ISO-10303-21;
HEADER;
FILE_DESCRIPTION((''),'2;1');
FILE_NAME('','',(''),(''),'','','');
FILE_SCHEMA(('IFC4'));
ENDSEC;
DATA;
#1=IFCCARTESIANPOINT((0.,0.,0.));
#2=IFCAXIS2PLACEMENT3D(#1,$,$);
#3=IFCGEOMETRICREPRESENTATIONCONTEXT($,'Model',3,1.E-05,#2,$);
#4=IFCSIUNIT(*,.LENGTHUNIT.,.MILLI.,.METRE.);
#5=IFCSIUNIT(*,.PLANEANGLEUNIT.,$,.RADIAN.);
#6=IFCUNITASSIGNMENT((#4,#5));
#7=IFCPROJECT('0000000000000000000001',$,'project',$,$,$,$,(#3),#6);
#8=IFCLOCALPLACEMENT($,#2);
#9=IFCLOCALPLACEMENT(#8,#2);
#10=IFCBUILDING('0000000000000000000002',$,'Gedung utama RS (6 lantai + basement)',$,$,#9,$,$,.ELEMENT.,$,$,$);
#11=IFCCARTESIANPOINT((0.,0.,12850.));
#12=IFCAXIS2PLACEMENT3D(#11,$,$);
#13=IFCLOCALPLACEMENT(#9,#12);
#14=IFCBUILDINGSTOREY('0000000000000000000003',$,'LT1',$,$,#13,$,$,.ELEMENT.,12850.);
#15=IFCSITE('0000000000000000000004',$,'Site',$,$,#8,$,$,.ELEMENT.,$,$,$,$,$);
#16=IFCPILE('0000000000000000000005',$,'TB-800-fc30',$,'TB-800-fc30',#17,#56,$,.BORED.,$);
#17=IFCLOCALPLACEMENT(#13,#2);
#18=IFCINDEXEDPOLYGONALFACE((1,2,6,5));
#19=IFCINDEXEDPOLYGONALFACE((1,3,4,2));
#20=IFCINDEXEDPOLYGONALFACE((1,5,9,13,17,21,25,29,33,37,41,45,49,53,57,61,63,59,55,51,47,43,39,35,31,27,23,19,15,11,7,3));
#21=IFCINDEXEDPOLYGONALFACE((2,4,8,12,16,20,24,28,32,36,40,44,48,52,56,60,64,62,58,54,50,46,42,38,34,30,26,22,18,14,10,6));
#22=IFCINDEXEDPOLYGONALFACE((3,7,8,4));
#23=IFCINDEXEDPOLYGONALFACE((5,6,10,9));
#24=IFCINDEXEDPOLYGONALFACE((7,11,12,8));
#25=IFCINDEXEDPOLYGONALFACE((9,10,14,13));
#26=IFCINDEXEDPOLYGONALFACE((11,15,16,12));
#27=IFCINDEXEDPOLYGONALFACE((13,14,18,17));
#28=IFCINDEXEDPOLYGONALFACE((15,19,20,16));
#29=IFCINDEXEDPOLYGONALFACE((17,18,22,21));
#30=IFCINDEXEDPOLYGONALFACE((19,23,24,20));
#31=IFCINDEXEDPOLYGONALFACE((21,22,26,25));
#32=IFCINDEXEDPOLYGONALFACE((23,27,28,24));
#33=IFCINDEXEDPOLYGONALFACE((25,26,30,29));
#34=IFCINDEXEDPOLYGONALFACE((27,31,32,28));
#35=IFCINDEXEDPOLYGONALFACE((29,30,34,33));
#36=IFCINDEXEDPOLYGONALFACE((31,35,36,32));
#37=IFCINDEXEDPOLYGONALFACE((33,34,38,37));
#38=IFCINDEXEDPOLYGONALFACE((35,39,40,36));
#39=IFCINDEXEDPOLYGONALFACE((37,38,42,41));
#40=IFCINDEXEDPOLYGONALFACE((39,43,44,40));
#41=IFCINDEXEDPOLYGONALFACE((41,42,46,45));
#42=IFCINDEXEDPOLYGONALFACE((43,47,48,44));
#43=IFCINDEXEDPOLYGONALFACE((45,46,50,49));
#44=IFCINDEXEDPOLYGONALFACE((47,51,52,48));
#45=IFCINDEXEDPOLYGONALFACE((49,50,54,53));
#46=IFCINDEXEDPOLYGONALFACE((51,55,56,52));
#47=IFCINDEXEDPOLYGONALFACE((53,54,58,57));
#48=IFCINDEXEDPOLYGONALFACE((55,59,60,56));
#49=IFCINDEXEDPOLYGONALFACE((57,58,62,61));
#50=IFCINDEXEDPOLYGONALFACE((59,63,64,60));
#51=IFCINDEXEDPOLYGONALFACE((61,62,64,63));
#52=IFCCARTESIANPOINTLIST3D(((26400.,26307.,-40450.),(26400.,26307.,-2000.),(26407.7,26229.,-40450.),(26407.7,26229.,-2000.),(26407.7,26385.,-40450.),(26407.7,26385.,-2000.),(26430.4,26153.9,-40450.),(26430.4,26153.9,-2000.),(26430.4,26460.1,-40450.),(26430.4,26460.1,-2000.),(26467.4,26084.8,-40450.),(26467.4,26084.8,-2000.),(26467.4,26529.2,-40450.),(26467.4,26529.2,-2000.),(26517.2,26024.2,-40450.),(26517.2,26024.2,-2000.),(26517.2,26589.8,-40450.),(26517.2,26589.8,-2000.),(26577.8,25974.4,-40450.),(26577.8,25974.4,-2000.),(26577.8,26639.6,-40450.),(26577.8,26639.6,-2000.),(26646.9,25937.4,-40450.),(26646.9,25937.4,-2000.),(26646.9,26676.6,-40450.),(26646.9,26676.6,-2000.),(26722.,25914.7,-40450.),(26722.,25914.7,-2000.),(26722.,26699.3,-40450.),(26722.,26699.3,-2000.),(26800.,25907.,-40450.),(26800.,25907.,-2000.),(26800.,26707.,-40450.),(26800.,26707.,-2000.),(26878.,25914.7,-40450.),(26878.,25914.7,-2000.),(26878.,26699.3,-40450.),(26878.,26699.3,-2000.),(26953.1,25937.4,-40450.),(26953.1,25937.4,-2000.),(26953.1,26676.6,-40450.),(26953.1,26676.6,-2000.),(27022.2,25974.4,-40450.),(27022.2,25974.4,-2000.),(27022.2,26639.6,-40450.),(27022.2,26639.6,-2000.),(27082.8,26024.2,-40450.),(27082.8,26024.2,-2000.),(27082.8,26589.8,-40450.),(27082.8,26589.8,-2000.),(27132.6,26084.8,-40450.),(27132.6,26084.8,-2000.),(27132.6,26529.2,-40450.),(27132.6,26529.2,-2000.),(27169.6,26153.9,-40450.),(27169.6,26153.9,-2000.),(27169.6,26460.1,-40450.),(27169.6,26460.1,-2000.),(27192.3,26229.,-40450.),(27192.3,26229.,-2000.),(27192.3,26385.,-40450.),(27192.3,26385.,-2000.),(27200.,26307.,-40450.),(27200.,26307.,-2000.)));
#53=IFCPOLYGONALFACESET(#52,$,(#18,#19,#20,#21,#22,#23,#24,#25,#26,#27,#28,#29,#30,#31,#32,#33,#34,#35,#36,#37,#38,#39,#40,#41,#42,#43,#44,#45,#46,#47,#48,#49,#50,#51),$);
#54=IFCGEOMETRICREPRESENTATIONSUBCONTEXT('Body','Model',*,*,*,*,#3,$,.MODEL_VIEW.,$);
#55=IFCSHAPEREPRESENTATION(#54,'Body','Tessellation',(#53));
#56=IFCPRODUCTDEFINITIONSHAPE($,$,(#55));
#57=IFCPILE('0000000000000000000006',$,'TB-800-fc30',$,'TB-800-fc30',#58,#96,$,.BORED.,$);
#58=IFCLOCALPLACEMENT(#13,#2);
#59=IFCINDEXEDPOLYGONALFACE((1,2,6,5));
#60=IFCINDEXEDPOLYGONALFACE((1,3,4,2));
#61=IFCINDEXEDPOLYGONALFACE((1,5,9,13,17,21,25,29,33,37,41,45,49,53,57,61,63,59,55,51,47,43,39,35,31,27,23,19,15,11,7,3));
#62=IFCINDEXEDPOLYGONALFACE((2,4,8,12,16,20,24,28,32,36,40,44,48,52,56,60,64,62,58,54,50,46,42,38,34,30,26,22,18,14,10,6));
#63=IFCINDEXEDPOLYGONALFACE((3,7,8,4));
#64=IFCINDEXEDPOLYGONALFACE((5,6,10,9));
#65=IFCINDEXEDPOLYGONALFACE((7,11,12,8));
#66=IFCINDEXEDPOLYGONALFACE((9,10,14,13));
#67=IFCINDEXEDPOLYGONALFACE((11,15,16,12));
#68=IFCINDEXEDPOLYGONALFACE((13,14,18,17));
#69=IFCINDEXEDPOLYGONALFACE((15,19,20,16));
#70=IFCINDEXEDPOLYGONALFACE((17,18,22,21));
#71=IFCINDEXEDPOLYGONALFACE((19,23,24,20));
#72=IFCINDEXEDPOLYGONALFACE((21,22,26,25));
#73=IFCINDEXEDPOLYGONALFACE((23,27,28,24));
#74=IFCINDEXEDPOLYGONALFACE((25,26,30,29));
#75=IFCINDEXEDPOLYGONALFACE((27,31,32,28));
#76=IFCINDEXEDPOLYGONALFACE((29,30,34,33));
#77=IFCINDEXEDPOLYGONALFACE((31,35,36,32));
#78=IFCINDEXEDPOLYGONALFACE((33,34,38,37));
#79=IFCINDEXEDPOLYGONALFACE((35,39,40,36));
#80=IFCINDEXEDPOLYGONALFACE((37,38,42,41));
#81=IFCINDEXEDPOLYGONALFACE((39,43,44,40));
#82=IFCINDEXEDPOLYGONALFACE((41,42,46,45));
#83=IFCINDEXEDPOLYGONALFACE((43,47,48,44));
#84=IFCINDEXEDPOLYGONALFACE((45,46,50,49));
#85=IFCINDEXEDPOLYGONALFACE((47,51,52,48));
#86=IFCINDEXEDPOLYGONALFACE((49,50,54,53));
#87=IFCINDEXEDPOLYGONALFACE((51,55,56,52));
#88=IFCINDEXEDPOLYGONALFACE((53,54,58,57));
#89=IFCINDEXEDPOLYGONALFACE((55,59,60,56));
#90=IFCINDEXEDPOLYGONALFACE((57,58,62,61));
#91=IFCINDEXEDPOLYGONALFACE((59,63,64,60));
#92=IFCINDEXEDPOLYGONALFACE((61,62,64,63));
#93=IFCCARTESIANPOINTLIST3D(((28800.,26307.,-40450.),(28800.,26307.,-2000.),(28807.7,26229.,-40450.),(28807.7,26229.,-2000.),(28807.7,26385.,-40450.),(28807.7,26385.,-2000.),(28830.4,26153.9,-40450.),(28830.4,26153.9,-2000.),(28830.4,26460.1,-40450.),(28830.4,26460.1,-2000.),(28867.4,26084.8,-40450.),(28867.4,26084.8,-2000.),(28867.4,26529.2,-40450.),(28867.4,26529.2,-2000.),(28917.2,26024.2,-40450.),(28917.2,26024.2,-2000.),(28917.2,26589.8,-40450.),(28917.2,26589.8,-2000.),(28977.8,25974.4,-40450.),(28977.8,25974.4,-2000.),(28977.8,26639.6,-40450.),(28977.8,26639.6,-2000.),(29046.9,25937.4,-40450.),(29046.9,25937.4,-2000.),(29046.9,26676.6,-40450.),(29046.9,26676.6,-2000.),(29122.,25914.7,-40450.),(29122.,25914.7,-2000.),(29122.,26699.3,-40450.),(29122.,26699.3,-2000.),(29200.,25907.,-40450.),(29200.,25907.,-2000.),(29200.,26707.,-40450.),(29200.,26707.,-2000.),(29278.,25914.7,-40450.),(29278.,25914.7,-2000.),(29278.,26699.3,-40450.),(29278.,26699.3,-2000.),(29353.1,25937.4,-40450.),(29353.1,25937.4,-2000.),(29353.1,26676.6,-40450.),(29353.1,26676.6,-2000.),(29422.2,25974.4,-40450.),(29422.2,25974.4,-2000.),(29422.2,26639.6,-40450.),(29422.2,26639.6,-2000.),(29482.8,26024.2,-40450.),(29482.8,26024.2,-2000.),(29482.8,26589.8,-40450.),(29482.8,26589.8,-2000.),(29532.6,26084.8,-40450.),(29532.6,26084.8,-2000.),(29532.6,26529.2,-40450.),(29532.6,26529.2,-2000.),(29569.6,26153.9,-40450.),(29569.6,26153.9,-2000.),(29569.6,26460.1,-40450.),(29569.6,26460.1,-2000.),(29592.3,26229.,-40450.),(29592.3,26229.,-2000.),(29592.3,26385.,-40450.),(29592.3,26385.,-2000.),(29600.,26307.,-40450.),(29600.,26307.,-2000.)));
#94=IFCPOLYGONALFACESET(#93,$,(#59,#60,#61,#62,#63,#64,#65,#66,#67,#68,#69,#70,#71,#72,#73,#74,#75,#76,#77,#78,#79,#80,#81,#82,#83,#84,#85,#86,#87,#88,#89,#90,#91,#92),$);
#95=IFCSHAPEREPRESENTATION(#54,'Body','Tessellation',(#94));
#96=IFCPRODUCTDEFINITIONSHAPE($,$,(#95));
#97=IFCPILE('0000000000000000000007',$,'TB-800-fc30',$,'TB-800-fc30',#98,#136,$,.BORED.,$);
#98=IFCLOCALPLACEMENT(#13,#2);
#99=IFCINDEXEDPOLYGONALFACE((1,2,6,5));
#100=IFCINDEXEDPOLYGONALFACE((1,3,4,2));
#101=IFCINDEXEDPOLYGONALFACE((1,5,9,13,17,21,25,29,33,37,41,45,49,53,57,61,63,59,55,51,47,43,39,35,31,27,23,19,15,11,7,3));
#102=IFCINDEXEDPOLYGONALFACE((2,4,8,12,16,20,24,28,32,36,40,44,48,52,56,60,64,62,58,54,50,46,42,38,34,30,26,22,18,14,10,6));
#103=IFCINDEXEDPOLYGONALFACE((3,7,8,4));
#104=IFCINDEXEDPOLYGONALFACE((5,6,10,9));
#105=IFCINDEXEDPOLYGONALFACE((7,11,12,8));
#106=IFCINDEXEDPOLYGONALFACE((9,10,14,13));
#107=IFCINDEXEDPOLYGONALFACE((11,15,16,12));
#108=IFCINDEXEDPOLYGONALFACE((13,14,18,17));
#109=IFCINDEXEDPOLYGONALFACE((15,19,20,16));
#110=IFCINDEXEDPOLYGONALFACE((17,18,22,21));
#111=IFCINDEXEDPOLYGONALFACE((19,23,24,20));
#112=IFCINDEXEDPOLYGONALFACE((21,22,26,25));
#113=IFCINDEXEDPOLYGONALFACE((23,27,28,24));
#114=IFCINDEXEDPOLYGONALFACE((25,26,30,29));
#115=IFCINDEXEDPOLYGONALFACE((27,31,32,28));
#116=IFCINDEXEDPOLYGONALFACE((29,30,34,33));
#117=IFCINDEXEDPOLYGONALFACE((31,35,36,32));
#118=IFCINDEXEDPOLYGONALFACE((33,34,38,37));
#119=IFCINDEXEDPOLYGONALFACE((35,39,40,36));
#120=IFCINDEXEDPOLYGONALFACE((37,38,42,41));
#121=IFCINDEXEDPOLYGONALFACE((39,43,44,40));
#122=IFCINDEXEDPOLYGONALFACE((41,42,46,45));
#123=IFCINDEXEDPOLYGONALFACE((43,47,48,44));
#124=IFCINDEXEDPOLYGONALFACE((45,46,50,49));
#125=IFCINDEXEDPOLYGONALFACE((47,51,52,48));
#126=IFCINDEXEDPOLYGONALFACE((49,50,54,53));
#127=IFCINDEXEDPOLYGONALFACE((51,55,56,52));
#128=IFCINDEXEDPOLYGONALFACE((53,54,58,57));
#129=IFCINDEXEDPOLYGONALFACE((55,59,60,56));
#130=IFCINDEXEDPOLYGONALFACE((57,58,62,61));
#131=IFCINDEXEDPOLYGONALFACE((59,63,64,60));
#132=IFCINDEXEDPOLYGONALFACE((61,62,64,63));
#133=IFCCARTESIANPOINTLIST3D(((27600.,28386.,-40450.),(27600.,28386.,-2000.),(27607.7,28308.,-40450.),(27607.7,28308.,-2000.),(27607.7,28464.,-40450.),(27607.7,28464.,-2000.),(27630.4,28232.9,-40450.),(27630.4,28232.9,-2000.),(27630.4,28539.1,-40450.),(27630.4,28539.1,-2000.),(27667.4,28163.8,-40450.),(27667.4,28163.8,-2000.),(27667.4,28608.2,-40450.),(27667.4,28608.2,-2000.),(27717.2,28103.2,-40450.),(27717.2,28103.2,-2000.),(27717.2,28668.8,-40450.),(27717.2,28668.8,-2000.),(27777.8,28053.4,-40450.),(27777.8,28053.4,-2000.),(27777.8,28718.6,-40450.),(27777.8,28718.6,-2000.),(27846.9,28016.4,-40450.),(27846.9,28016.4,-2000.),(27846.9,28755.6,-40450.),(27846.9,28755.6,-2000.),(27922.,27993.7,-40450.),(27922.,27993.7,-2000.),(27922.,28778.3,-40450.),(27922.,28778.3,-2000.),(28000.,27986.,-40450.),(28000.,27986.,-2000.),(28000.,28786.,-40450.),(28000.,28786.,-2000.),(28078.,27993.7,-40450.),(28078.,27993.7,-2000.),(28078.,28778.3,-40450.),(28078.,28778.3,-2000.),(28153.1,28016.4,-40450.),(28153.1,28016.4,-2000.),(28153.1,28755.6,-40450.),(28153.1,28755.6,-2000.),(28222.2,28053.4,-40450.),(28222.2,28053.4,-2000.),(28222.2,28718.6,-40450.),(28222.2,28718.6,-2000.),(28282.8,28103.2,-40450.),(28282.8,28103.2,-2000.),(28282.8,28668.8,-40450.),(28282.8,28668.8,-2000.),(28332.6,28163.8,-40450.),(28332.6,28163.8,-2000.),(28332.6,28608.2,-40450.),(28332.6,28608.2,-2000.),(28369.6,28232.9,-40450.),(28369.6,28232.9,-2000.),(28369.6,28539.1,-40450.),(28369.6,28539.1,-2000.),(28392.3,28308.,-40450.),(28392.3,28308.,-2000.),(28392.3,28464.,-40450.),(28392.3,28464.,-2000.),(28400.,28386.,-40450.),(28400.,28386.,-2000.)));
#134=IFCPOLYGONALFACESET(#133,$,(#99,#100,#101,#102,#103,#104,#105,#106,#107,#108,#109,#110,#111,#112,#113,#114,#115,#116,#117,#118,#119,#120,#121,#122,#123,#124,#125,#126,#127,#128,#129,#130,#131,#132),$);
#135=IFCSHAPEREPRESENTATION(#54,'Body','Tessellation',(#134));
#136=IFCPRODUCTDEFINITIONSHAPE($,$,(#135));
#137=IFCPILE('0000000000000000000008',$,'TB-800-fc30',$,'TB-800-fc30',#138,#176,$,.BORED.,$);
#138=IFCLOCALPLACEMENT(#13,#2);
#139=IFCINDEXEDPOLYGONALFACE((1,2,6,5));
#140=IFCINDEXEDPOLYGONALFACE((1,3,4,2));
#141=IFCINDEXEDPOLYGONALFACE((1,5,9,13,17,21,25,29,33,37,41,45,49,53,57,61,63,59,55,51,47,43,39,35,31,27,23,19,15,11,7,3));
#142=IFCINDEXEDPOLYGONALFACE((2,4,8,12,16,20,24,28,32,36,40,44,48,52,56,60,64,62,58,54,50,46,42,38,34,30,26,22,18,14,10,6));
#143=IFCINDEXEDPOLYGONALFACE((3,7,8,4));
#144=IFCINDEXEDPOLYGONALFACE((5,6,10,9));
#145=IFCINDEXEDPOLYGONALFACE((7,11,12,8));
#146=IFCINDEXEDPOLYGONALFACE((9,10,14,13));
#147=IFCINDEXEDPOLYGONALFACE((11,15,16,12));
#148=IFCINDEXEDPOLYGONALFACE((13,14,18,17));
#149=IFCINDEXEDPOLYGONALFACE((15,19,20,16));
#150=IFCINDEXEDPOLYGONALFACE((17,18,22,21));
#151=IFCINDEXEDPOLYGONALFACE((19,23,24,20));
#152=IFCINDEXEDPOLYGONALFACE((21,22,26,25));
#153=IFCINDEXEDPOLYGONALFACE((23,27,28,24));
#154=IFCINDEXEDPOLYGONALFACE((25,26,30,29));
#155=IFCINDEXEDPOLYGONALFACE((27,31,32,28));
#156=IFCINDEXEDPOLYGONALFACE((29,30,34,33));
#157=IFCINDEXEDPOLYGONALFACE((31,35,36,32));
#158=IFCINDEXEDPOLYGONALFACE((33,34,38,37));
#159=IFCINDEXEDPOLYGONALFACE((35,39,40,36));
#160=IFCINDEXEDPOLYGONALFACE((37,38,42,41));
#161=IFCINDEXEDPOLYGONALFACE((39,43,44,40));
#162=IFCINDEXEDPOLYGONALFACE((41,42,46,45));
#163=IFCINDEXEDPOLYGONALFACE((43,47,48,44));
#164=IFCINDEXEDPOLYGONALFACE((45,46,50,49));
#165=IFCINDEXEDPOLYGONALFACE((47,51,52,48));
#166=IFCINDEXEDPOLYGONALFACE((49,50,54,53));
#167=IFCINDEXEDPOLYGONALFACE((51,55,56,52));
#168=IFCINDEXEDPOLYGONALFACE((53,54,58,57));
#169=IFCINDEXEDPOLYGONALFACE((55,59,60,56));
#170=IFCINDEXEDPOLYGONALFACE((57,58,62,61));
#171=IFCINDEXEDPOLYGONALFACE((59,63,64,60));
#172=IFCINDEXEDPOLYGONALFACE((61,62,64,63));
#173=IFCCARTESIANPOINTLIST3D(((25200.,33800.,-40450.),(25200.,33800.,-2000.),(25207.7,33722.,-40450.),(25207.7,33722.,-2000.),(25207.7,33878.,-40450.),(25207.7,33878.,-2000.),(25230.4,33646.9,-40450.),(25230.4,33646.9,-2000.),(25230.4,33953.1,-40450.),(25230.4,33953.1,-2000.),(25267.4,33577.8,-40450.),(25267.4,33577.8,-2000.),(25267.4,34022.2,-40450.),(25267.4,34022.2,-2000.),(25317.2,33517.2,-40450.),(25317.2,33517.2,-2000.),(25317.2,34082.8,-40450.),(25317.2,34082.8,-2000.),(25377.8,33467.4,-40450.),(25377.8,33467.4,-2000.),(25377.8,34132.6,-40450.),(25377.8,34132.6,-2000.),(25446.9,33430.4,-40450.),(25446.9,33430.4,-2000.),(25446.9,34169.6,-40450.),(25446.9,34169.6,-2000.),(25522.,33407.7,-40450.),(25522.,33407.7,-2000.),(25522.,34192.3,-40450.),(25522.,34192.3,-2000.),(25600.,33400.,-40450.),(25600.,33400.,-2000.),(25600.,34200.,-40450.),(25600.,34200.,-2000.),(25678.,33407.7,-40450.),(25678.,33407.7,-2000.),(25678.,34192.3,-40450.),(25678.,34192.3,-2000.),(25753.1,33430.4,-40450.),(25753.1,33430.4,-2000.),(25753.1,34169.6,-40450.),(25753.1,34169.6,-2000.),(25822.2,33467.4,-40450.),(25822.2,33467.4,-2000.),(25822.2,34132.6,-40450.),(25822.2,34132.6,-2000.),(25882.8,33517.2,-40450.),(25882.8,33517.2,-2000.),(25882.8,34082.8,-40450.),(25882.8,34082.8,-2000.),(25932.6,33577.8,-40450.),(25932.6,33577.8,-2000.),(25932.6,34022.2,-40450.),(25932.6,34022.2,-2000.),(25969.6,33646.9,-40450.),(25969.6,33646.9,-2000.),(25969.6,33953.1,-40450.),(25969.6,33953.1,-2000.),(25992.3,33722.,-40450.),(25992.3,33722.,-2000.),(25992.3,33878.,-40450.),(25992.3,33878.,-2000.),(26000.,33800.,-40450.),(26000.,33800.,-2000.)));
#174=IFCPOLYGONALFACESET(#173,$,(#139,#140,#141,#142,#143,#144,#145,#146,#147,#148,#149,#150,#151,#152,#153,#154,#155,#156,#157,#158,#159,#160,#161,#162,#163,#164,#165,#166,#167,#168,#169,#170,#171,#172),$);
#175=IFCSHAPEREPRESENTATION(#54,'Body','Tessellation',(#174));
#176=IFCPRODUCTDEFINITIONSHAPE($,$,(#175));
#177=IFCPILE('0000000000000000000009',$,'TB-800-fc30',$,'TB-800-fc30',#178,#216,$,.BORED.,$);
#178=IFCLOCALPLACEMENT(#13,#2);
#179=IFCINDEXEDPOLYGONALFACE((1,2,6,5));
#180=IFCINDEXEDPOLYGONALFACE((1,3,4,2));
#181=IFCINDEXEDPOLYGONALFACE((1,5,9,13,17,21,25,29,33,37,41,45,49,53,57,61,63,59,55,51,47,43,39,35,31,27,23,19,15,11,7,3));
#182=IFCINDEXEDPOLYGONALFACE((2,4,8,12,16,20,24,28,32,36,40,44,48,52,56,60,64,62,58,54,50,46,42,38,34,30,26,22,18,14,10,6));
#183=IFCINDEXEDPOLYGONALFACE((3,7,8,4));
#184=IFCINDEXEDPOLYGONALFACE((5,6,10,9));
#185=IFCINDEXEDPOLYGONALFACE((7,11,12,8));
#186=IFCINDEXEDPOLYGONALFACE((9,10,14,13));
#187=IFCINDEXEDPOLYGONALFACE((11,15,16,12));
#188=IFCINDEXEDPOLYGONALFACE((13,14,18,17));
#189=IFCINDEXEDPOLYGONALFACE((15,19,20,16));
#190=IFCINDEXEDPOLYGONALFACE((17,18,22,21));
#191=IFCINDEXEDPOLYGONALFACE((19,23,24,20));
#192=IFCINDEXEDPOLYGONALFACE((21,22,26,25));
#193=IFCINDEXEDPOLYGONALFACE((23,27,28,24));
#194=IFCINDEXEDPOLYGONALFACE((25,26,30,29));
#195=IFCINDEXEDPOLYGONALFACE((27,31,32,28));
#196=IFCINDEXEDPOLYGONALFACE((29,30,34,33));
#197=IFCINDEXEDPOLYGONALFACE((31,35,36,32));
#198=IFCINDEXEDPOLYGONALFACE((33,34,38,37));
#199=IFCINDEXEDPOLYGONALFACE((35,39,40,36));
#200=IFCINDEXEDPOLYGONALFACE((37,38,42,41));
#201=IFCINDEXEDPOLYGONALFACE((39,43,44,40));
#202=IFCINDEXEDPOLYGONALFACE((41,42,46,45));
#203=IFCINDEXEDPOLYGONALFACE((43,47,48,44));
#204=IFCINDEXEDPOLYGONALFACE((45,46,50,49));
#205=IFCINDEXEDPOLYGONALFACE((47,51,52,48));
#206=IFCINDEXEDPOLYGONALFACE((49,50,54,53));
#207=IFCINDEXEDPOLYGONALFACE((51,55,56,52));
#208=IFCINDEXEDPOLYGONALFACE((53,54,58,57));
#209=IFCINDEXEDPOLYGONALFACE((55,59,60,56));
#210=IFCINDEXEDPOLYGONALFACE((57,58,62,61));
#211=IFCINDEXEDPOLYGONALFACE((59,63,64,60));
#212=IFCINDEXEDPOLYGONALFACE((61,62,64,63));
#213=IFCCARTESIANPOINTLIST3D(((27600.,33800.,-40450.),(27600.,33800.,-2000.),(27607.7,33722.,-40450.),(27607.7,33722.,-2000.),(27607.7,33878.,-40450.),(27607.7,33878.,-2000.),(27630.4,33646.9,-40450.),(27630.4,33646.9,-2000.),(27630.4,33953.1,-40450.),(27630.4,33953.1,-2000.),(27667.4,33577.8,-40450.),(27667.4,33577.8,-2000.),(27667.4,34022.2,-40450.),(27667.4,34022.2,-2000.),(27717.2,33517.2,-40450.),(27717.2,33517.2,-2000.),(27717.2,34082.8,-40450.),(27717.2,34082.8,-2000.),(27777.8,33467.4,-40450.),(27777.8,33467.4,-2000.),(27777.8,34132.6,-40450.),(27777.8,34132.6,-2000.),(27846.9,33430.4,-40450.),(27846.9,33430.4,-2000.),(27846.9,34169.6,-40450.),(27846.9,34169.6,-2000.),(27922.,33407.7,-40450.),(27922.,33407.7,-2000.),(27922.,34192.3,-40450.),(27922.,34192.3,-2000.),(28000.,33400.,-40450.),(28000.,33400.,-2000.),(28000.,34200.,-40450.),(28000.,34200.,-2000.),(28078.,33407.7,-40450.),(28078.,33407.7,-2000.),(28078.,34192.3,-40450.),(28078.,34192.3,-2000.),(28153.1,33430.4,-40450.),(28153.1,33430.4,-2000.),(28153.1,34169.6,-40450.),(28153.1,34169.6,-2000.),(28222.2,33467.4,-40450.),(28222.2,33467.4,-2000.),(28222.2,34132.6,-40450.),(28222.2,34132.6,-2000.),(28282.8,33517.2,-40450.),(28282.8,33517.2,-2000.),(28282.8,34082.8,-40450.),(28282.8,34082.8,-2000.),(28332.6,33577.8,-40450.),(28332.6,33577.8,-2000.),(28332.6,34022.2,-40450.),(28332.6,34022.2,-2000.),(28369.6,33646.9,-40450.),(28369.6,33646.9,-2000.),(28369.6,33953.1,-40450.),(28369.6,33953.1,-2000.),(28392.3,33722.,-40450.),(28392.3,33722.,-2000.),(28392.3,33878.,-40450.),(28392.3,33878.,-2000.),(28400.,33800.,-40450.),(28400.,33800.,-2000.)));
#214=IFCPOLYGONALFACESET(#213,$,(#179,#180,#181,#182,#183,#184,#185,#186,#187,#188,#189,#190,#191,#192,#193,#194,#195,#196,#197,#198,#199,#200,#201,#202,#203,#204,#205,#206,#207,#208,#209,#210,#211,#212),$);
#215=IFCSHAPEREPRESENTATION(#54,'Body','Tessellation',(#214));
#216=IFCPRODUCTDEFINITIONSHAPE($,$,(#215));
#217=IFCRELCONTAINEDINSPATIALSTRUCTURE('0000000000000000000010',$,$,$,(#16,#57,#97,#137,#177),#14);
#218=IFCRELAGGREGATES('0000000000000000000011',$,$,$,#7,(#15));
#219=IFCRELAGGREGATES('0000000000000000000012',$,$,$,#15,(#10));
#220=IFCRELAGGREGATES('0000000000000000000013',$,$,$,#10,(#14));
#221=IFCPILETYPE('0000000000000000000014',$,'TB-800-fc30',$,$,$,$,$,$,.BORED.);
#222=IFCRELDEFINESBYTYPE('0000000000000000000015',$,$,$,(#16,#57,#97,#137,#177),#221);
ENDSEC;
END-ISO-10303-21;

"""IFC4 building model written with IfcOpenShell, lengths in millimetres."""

from ifc_helpers import new_model, si_unit, frame, origin, origin_2d, place, context, subcontext, project, spatial, circle, extrude, material_profile, profile_set, profile_usage, type_object, element, save


model = new_model("IFC4")

# Units and contexts
model_context = context("Model", 3, precision=1e-05, world=origin())
body_context = subcontext(model_context, "Body", "Model", "MODEL_VIEW")
ifc_project = project(units=[si_unit("LENGTHUNIT", "METRE", prefix="MILLI"), si_unit("PLANEANGLEUNIT", "RADIAN")], contexts=[model_context])

# Site, building, storey
site_placement = place(None, origin())
site = spatial("IfcSite", under=ifc_project, at=site_placement, Name="Site", CompositionType="ELEMENT")
building_placement = place(site_placement, origin())
building = spatial("IfcBuilding", under=site, at=building_placement, Name="Gedung utama RS (6 lantai + basement)", CompositionType="ELEMENT")
storey_placement = place(building_placement, frame((0.0, 0.0, 12850.0)))
storey = spatial("IfcBuildingStorey", under=building, at=storey_placement, Name="LT1", CompositionType="ELEMENT", Elevation=12850.0)

# Piles
ifc_material_profile_1 = material_profile(None, circle(Radius=400.0, at=origin_2d()), Name="TB-800-fc30")
ifc_profile_set_1 = profile_set([ifc_material_profile_1], Name="TB-800-fc30")
ifc_profile_usage_1 = profile_usage(ifc_profile_set_1, cardinal=5)
pile_type = type_object("IfcPileType", Name="TB-800-fc30", PredefinedType="BORED", material=ifc_profile_set_1)
for number, where, z_axis, x_axis, name in (
    (1, (26800.0, 26307.0, -40450.0), (0.0, 0.0, 1.0), (1.0, 0.0, 0.0), "TB-800-fc30"),
    (2, (29200.0, 26307.0, -40450.0), (0.0, 0.0, 1.0), (1.0, 0.0, 0.0), "TB-800-fc30"),
    (3, (28000.0, 28386.0, -40450.0), (0.0, 0.0, 1.0), (1.0, 0.0, 0.0), "TB-800-fc30"),
    (4, (25600.0, 33800.0, -40450.0), (0.0, 0.0, 1.0), (1.0, 0.0, 0.0), "TB-800-fc30"),
    (5, (28000.0, 33800.0, -40450.0), (0.0, 0.0, 1.0), (1.0, 0.0, 0.0), "TB-800-fc30"),
):
    element("IfcPile", number, at=place(storey_placement, frame(where, z_axis=z_axis, x_axis=x_axis)), inside=storey, type_object=pile_type, material=ifc_profile_usage_1, Name=name, ObjectType="TB-800-fc30", PredefinedType="BORED", context=body_context, shape_type="SweptSolid", body=[
        extrude(circle(Radius=400.0, at=origin_2d()), origin(), (0.0, 0.0, 1.0), 38450.0),
    ])

save(model, "model.ifc")
